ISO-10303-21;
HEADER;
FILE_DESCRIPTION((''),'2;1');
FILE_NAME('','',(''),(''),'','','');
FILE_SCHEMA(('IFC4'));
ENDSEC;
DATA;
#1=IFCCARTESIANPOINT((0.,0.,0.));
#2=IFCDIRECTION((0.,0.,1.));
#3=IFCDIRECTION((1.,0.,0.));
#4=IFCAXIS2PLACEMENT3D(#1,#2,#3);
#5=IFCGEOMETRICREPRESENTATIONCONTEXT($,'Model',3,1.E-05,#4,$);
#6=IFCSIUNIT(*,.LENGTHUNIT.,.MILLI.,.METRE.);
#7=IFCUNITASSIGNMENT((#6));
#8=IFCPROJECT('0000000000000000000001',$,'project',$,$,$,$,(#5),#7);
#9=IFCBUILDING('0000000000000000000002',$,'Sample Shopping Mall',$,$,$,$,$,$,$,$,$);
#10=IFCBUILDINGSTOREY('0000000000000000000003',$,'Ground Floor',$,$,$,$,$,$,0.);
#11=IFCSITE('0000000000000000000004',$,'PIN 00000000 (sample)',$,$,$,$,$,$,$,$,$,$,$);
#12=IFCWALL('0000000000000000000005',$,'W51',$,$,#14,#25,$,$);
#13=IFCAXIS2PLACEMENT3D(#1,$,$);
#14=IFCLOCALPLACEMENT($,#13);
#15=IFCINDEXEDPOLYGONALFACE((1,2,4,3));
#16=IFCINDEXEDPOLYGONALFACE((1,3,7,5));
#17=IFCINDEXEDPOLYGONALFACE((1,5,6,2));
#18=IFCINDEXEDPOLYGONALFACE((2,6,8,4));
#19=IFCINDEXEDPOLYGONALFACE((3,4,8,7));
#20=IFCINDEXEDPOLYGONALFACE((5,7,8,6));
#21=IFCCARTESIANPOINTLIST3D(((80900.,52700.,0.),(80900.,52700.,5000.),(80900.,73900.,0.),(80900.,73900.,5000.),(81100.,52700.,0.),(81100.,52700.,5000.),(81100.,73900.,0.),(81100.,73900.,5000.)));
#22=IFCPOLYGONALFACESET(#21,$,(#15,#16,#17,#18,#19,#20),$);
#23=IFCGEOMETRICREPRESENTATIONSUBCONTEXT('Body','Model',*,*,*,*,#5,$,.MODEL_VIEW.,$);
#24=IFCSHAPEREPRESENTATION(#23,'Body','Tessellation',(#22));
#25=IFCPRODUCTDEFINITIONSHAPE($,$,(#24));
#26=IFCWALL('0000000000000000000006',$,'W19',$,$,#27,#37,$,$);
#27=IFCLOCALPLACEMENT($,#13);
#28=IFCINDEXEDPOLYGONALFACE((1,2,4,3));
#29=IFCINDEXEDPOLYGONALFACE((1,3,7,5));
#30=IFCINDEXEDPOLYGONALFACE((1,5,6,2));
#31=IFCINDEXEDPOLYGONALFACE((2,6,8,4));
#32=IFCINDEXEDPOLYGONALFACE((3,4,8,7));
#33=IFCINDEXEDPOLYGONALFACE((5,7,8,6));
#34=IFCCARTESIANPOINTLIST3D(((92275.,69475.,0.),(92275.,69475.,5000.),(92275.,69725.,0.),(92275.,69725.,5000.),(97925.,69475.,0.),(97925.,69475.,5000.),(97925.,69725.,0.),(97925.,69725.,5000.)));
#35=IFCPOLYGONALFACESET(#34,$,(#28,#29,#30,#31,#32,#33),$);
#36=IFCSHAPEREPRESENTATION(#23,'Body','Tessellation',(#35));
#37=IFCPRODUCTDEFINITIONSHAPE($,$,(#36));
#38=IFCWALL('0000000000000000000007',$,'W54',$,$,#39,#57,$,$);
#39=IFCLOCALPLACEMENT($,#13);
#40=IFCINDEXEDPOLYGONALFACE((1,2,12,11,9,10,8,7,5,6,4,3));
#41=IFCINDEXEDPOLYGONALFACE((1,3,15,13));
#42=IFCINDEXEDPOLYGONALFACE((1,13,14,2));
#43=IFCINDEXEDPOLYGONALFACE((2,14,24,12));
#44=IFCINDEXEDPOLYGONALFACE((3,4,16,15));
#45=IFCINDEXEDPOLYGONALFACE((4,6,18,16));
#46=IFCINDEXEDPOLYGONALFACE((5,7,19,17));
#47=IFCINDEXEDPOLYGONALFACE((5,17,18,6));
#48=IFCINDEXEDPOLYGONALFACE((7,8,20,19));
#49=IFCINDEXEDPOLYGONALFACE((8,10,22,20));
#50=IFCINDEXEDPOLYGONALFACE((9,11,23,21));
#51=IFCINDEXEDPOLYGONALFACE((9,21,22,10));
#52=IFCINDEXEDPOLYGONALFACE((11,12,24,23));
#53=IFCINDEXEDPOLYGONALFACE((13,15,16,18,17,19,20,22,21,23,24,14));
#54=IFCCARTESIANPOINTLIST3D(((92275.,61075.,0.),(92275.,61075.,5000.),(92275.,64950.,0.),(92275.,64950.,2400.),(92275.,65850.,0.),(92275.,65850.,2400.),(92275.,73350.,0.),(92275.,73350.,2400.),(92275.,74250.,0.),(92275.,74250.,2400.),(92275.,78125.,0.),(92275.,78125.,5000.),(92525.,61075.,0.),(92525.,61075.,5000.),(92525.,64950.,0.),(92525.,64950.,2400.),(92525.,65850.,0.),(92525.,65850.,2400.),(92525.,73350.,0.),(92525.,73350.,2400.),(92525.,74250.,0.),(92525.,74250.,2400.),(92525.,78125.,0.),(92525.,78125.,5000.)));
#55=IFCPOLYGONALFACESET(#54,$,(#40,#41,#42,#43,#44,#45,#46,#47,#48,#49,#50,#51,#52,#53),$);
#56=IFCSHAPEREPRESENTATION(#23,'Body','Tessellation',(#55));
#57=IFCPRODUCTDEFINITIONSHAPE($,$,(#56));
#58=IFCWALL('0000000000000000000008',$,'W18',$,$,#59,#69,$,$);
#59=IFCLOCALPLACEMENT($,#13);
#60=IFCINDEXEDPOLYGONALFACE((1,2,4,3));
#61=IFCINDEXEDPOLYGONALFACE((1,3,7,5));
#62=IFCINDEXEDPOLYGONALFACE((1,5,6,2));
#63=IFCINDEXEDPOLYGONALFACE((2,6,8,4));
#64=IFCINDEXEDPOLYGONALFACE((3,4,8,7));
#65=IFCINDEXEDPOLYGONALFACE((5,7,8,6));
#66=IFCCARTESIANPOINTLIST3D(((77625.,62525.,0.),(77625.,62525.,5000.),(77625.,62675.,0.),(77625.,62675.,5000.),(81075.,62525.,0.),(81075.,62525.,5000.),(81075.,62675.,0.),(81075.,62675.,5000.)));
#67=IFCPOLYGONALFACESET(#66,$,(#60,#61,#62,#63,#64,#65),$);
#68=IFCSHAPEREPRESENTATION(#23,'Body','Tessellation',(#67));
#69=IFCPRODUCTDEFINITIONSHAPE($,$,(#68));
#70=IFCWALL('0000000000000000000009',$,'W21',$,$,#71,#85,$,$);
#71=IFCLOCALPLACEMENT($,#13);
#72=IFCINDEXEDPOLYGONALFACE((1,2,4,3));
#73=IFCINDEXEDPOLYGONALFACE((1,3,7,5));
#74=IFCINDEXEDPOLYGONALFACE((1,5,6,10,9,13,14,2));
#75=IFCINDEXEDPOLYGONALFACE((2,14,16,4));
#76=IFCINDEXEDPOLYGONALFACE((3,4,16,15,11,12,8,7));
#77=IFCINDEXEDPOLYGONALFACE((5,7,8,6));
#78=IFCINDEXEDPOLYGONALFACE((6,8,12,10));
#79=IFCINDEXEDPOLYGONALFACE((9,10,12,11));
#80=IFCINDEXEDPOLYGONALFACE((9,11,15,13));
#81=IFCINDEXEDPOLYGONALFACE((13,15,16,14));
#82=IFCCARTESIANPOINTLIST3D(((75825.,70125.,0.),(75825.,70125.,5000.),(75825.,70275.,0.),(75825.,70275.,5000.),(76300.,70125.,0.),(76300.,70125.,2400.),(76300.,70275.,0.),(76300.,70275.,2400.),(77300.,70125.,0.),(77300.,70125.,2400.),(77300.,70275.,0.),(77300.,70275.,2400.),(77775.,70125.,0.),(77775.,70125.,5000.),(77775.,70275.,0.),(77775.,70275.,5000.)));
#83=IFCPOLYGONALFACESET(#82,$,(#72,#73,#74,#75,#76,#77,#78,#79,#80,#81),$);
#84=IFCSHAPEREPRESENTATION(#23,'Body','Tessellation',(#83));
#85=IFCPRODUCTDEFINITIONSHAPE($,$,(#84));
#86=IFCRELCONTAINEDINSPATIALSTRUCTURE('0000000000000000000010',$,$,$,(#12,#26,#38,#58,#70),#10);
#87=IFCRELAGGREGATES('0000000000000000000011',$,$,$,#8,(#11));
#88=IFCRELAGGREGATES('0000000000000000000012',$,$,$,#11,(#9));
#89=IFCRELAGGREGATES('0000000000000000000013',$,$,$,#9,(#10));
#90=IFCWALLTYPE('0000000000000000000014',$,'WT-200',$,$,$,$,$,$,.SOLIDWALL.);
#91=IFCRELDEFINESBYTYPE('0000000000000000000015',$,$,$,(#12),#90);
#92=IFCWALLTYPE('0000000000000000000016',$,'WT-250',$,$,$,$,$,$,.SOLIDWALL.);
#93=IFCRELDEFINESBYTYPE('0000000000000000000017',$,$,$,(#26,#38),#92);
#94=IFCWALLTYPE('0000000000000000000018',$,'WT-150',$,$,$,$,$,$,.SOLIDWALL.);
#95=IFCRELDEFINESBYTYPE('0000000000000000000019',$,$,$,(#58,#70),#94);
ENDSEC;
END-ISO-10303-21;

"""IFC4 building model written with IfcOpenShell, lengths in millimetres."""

from ifc_helpers import new_model, si_unit, frame, origin_with_axes, place, context, subcontext, project, spatial, indexed_curve, outline, extrude, type_object, element, save


model = new_model("IFC4")

# Units and contexts
model_context = context("Model", 3, precision=1e-05, world=origin_with_axes())
body_context = subcontext(model_context, "Body", "Model", "MODEL_VIEW")
ifc_project = project(units=[si_unit("LENGTHUNIT", "METRE", prefix="MILLI")], contexts=[model_context])

# Site, building, storey
site = spatial("IfcSite", under=ifc_project, Name="PIN 00000000 (sample)")
building = spatial("IfcBuilding", under=site, Name="Sample Shopping Mall")
storey = spatial("IfcBuildingStorey", under=building, Name="Ground Floor", Elevation=0.0)

# Wall
wall_type_1 = type_object("IfcWallType", Name="WT-200", PredefinedType="SOLIDWALL")
wall_1_placement = place(None, frame((81100.0, 52700.0, 0.0), z_axis=(0.0, 0.0, 1.0), x_axis=(0.0, 1.0, 0.0)))
element("IfcWall", 1, at=wall_1_placement, inside=storey, type_object=wall_type_1, Name="W51", context=body_context, shape_type="SweptSolid", body=[
    extrude(outline(indexed_curve([(0.0, 0.0), (0.0, 200.0), (21200.0, 200.0), (21200.0, 0.0), (0.0, 0.0)], self_intersect=False)), origin_with_axes(), (0.0, 0.0, 1.0), 5000.0),
])

# Shared definitions
wall_type_2 = type_object("IfcWallType", Name="WT-250", PredefinedType="SOLIDWALL")

# Wall
wall_2_placement = place(None, frame((92275.0, 69475.0, 0.0), z_axis=(0.0, 0.0, 1.0), x_axis=(1.0, 0.0, 0.0)))
element("IfcWall", 2, at=wall_2_placement, inside=storey, type_object=wall_type_2, Name="W19", context=body_context, shape_type="SweptSolid", body=[
    extrude(outline(indexed_curve([(0.0, 0.0), (0.0, 250.0), (5650.0, 250.0), (5650.0, 0.0), (0.0, 0.0)], self_intersect=False)), origin_with_axes(), (0.0, 0.0, 1.0), 5000.0),
])

# Wall, openings
wall_3_placement = place(None, frame((92525.0, 61075.0, 0.0), z_axis=(0.0, 0.0, 1.0), x_axis=(0.0, 1.0, 0.0)))
wall_3 = element("IfcWall", 3, at=wall_3_placement, inside=storey, type_object=wall_type_2, Name="W54", context=body_context, shape_type="SweptSolid", body=[
    extrude(outline(indexed_curve([(0.0, 0.0), (0.0, 250.0), (17050.0, 250.0), (17050.0, 0.0), (0.0, 0.0)], self_intersect=False)), origin_with_axes(), (0.0, 0.0, 1.0), 5000.0),
])
opening_1_placement = place(wall_3_placement, frame((3875.0, -100.0, 0.0), z_axis=(0.0, 0.0, 1.0), x_axis=(1.0, 0.0, 0.0)))
element("IfcOpeningElement", 4, at=opening_1_placement, cuts=wall_3, context=body_context, shape_type="SweptSolid", body=[
    extrude(outline(indexed_curve([(0.0, 0.0), (0.0, 450.0), (900.0, 450.0), (900.0, 0.0), (0.0, 0.0)], self_intersect=False)), origin_with_axes(), (0.0, 0.0, 1.0), 2400.0),
])
opening_2_placement = place(wall_3_placement, frame((12275.0, -100.0, 0.0), z_axis=(0.0, 0.0, 1.0), x_axis=(1.0, 0.0, 0.0)))
element("IfcOpeningElement", 5, at=opening_2_placement, cuts=wall_3, context=body_context, shape_type="SweptSolid", body=[
    extrude(outline(indexed_curve([(0.0, 0.0), (0.0, 450.0), (900.0, 450.0), (900.0, 0.0), (0.0, 0.0)], self_intersect=False)), origin_with_axes(), (0.0, 0.0, 1.0), 2400.0),
])

# Wall
wall_type_3 = type_object("IfcWallType", Name="WT-150", PredefinedType="SOLIDWALL")
wall_4_placement = place(None, frame((77625.0, 62525.0, 0.0), z_axis=(0.0, 0.0, 1.0), x_axis=(1.0, 0.0, 0.0)))
element("IfcWall", 6, at=wall_4_placement, inside=storey, type_object=wall_type_3, Name="W18", context=body_context, shape_type="SweptSolid", body=[
    extrude(outline(indexed_curve([(0.0, 0.0), (0.0, 150.0), (3450.0, 150.0), (3450.0, 0.0), (0.0, 0.0)], self_intersect=False)), origin_with_axes(), (0.0, 0.0, 1.0), 5000.0),
])

# Wall, opening
wall_5_placement = place(None, frame((75825.0, 70125.0, 0.0), z_axis=(0.0, 0.0, 1.0), x_axis=(1.0, 0.0, 0.0)))
wall_5 = element("IfcWall", 7, at=wall_5_placement, inside=storey, type_object=wall_type_3, Name="W21", context=body_context, shape_type="SweptSolid", body=[
    extrude(outline(indexed_curve([(0.0, 0.0), (0.0, 150.0), (1950.0, 150.0), (1950.0, 0.0), (0.0, 0.0)], self_intersect=False)), origin_with_axes(), (0.0, 0.0, 1.0), 5000.0),
])
opening_3_placement = place(wall_5_placement, frame((475.0, -100.0, 0.0), z_axis=(0.0, 0.0, 1.0), x_axis=(1.0, 0.0, 0.0)))
element("IfcOpeningElement", 8, at=opening_3_placement, cuts=wall_5, context=body_context, shape_type="SweptSolid", body=[
    extrude(outline(indexed_curve([(0.0, 0.0), (0.0, 350.0), (1000.0, 350.0), (1000.0, 0.0), (0.0, 0.0)], self_intersect=False)), origin_with_axes(), (0.0, 0.0, 1.0), 2400.0),
])

save(model, "model.ifc")
